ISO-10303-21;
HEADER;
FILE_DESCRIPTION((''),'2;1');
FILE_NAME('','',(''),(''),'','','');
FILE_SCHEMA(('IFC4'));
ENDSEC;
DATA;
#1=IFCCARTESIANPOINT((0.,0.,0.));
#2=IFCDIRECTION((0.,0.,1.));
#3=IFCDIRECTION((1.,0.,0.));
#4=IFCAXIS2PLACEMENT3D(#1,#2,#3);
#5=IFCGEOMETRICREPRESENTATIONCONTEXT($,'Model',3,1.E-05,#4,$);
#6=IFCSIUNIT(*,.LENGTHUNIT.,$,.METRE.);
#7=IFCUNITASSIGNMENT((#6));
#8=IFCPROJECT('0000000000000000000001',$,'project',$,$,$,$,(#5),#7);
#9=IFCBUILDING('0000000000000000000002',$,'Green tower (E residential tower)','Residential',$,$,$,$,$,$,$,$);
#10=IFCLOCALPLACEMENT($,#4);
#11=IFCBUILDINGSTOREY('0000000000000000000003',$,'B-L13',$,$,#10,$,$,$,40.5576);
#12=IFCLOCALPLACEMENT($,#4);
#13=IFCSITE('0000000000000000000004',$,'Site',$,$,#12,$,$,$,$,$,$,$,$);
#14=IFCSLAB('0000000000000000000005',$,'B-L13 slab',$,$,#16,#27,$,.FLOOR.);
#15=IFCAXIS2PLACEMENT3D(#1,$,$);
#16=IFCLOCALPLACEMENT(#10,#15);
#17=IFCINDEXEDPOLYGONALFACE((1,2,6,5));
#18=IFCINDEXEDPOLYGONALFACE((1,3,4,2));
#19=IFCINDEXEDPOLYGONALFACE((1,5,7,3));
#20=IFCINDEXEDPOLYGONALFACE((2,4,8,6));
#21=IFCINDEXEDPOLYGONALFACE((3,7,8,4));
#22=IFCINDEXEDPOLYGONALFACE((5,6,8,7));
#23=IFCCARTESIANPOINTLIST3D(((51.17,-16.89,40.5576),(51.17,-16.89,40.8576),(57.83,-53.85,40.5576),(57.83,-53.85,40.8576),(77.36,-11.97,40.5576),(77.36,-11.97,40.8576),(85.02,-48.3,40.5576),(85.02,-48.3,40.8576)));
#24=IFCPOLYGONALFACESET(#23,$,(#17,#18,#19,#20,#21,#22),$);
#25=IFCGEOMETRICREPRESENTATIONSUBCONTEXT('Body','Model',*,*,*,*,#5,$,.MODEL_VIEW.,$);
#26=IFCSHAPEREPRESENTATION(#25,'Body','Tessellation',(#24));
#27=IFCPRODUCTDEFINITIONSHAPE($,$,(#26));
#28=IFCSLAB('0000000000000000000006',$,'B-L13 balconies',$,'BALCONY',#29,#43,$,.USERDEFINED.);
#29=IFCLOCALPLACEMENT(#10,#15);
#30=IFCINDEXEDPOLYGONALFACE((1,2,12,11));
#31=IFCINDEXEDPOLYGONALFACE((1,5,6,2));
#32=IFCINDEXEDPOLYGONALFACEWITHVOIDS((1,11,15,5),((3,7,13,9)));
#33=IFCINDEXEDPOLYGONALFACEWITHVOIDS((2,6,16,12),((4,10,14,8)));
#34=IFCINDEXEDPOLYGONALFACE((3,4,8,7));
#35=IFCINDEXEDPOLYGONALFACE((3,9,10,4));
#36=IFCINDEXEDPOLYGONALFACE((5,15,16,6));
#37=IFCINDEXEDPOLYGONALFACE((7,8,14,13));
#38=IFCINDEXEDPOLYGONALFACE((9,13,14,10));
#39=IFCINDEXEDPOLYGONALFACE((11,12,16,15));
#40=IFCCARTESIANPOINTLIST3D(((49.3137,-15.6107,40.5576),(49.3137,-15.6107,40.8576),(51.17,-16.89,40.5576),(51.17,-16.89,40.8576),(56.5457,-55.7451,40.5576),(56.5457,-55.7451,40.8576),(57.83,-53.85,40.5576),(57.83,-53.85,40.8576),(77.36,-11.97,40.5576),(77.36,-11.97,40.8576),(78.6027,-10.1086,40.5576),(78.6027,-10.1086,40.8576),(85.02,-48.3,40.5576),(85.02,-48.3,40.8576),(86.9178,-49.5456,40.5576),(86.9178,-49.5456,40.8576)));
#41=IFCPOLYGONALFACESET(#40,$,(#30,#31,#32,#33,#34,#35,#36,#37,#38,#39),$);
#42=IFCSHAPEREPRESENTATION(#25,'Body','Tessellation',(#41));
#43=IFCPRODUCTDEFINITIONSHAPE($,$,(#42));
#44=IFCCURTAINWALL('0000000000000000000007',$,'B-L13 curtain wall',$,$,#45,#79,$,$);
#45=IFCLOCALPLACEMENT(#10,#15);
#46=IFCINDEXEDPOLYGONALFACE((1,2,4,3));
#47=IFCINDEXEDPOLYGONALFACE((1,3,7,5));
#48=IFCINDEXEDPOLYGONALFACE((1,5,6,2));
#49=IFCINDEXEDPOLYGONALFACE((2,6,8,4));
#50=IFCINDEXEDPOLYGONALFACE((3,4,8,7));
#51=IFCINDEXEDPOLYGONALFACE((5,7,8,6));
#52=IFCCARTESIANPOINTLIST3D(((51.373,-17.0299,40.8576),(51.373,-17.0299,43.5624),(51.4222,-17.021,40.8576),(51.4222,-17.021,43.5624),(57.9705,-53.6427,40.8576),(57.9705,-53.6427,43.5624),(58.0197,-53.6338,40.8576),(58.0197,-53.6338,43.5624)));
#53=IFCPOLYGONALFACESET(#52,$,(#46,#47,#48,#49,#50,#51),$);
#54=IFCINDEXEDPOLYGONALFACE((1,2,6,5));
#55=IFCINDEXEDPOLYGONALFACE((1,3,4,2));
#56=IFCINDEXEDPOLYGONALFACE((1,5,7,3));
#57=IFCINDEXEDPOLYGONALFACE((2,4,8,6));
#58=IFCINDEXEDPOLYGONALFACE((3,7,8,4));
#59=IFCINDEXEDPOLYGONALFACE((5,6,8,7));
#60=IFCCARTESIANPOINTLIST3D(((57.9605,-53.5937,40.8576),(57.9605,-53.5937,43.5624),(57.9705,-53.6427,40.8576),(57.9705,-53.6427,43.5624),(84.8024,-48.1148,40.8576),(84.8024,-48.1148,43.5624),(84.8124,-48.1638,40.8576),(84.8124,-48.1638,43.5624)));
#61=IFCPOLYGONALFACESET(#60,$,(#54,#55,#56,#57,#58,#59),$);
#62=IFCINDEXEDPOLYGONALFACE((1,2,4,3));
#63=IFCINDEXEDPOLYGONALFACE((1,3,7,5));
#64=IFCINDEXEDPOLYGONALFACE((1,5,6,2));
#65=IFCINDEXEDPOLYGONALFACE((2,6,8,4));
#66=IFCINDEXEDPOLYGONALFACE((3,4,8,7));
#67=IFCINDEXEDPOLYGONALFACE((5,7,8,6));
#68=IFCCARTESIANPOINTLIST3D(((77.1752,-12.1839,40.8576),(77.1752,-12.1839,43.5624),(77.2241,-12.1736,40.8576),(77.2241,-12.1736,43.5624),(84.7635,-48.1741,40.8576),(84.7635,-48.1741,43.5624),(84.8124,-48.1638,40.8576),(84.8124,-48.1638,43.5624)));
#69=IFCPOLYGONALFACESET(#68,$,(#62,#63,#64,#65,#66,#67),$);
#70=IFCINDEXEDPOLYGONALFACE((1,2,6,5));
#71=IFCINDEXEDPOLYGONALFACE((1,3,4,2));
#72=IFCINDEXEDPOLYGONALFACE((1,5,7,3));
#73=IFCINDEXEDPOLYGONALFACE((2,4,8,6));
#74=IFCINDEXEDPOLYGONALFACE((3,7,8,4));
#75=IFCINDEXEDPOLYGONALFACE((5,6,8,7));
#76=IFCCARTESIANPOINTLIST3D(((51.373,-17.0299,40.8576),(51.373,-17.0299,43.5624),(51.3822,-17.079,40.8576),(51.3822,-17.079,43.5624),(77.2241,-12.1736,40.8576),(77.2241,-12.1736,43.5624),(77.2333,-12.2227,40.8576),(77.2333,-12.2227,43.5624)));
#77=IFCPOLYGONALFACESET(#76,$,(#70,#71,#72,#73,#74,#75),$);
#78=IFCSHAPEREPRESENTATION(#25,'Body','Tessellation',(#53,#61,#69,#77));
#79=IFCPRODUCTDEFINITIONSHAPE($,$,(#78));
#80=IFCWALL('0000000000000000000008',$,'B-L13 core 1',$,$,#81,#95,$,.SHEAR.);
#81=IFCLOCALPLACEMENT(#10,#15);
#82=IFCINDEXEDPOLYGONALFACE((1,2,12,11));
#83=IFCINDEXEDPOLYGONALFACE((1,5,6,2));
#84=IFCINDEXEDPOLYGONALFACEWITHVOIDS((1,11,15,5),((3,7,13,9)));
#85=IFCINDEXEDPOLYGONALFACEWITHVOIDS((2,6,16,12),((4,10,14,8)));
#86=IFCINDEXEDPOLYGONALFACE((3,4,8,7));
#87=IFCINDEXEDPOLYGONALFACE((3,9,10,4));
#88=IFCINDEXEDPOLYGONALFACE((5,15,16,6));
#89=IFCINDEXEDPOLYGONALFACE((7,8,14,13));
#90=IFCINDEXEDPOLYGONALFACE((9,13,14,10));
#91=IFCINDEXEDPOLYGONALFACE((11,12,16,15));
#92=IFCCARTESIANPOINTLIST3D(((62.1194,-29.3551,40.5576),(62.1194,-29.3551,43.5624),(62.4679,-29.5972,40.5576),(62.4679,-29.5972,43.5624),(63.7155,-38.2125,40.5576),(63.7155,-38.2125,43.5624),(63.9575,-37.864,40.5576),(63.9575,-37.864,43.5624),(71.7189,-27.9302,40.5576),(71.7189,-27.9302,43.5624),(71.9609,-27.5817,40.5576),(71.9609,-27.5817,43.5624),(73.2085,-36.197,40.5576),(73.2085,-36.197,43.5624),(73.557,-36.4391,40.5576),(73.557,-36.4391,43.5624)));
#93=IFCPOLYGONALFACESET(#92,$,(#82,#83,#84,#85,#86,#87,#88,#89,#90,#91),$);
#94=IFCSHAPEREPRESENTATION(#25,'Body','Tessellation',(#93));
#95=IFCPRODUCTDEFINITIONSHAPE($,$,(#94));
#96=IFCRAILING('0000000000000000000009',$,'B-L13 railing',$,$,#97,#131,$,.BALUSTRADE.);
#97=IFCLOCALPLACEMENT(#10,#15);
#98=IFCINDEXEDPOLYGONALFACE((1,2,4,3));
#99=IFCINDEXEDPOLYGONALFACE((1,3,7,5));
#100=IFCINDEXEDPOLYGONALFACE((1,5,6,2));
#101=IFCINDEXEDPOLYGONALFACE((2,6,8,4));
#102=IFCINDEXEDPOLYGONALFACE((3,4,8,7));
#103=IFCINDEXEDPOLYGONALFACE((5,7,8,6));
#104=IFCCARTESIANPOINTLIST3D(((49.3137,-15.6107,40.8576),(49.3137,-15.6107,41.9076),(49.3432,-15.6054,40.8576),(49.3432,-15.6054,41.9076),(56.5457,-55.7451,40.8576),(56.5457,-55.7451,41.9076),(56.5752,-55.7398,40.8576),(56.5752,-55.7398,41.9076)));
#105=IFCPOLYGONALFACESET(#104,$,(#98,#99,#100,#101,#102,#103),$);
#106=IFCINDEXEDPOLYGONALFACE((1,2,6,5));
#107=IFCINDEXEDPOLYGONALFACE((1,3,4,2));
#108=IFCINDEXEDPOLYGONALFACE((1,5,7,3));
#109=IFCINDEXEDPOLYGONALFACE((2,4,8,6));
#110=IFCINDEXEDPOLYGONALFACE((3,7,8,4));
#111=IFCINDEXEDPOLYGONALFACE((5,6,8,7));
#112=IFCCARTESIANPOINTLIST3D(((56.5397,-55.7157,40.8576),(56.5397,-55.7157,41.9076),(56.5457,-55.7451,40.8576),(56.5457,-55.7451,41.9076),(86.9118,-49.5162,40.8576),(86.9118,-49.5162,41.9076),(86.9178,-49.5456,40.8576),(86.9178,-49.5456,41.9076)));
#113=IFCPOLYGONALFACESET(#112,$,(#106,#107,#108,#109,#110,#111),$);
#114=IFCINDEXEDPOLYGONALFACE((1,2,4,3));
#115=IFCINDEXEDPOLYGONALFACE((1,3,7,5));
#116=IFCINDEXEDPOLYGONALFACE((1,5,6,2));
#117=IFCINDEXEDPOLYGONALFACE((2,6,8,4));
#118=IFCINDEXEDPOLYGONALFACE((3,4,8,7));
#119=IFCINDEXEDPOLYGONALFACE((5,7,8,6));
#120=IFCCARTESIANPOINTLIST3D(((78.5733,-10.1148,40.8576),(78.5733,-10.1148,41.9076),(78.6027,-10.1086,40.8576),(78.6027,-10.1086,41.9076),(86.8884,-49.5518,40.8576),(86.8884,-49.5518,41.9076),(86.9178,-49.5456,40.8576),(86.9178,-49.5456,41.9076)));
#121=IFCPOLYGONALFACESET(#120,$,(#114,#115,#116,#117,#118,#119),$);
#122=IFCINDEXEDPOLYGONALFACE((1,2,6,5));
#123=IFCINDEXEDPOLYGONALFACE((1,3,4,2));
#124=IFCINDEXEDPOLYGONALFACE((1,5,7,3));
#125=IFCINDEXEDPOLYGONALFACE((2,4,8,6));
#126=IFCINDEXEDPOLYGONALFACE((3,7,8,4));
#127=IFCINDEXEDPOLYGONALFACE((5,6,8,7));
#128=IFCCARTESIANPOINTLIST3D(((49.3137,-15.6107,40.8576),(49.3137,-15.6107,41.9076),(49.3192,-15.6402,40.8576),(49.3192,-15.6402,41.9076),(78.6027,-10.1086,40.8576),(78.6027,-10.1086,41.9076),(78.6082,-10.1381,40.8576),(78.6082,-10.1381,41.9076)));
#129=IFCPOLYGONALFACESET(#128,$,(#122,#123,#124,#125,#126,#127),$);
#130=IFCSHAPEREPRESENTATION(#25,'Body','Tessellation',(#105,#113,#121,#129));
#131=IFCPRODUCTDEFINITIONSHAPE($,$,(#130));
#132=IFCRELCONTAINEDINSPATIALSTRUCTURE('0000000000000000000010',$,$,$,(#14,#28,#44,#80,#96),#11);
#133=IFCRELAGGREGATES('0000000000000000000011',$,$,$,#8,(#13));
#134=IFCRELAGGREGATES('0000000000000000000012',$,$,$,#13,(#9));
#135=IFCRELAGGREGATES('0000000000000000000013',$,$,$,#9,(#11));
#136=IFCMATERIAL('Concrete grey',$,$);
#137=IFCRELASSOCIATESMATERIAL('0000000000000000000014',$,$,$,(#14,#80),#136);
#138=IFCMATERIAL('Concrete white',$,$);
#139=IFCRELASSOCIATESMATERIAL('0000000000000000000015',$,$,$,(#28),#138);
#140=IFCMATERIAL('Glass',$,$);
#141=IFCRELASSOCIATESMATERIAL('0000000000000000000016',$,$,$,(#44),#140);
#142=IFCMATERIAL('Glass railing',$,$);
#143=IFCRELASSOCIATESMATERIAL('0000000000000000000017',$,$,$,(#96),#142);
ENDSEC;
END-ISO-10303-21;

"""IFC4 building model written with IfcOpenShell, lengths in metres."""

from ifc_helpers import new_model, si_unit, frame, origin_with_axes, place, context, subcontext, project, spatial, polyline, outline, extrude, material, element, save


model = new_model("IFC4")

# Units and contexts
model_context = context("Model", 3, precision=1e-05, world=origin_with_axes())
body_context = subcontext(model_context, "Body", "Model", "MODEL_VIEW")
ifc_project = project(units=[si_unit("LENGTHUNIT", "METRE")], contexts=[model_context])

# Site, building, storey
site_placement = place(None, origin_with_axes())
site = spatial("IfcSite", under=ifc_project, at=site_placement, Name="Site")
building = spatial("IfcBuilding", under=site, Name="Green tower (E residential tower)", Description="Residential")
storey_placement = place(None, origin_with_axes())
storey = spatial("IfcBuildingStorey", under=building, at=storey_placement, Name="B-L13", Elevation=40.5576)

# Slabs
ifc_material_1 = material(Name="Concrete grey")
slab_1_placement = place(storey_placement, origin_with_axes())
element("IfcSlab", 1, at=slab_1_placement, inside=storey, material=ifc_material_1, Name="B-L13 slab", PredefinedType="FLOOR", context=body_context, shape_type="SweptSolid", body=[
    extrude(outline(polyline([(51.17, -16.89), (57.83, -53.85), (85.02, -48.3), (77.36, -11.97), (51.17, -16.89)])), frame((0.0, 0.0, 40.5576), z_axis=(0.0, 0.0, 1.0), x_axis=(1.0, 0.0, 0.0)), (0.0, 0.0, 1.0), 0.3),
])
ifc_material_2 = material(Name="Concrete white")
slab_2_placement = place(storey_placement, origin_with_axes())
element("IfcSlab", 2, at=slab_2_placement, inside=storey, material=ifc_material_2, Name="B-L13 balconies", ObjectType="BALCONY", PredefinedType="USERDEFINED", context=body_context, shape_type="SweptSolid", body=[
    extrude(outline(polyline([(49.3137, -15.6107), (56.5457, -55.7451), (86.9178, -49.5456), (78.6027, -10.1086), (49.3137, -15.6107)]), holes=[polyline([(51.17, -16.89), (57.83, -53.85), (85.02, -48.3), (77.36, -11.97), (51.17, -16.89)])]), frame((0.0, 0.0, 40.5576), z_axis=(0.0, 0.0, 1.0), x_axis=(1.0, 0.0, 0.0)), (0.0, 0.0, 1.0), 0.3),
])

# Curtain wall
ifc_material_3 = material(Name="Glass")
curtain_wall_placement = place(storey_placement, origin_with_axes())
element("IfcCurtainWall", 3, at=curtain_wall_placement, inside=storey, material=ifc_material_3, Name="B-L13 curtain wall", context=body_context, shape_type="SweptSolid", body=[
    extrude(outline(polyline([(51.373, -17.0299), (57.9705, -53.6427), (58.0197, -53.6338), (51.4222, -17.021), (51.373, -17.0299)])), frame((0.0, 0.0, 40.8576), z_axis=(0.0, 0.0, 1.0), x_axis=(1.0, 0.0, 0.0)), (0.0, 0.0, 1.0), 2.7048),
    extrude(outline(polyline([(57.9705, -53.6427), (84.8124, -48.1638), (84.8024, -48.1148), (57.9605, -53.5937), (57.9705, -53.6427)])), frame((0.0, 0.0, 40.8576), z_axis=(0.0, 0.0, 1.0), x_axis=(1.0, 0.0, 0.0)), (0.0, 0.0, 1.0), 2.7048),
    extrude(outline(polyline([(84.8124, -48.1638), (77.2241, -12.1736), (77.1752, -12.1839), (84.7635, -48.1741), (84.8124, -48.1638)])), frame((0.0, 0.0, 40.8576), z_axis=(0.0, 0.0, 1.0), x_axis=(1.0, 0.0, 0.0)), (0.0, 0.0, 1.0), 2.7048),
    extrude(outline(polyline([(77.2241, -12.1736), (51.373, -17.0299), (51.3822, -17.079), (77.2333, -12.2227), (77.2241, -12.1736)])), frame((0.0, 0.0, 40.8576), z_axis=(0.0, 0.0, 1.0), x_axis=(1.0, 0.0, 0.0)), (0.0, 0.0, 1.0), 2.7048),
])

# Wall
wall_placement = place(storey_placement, origin_with_axes())
element("IfcWall", 4, at=wall_placement, inside=storey, material=ifc_material_1, Name="B-L13 core 1", PredefinedType="SHEAR", context=body_context, shape_type="SweptSolid", body=[
    extrude(outline(polyline([(62.1194, -29.3551), (63.7155, -38.2125), (73.557, -36.4391), (71.9609, -27.5817), (62.1194, -29.3551)]), holes=[polyline([(62.4679, -29.5972), (63.9575, -37.864), (73.2085, -36.197), (71.7189, -27.9302), (62.4679, -29.5972)])]), frame((0.0, 0.0, 40.5576), z_axis=(0.0, 0.0, 1.0), x_axis=(1.0, 0.0, 0.0)), (0.0, 0.0, 1.0), 3.0048),
])

# Railing
ifc_material_4 = material(Name="Glass railing")
railing_placement = place(storey_placement, origin_with_axes())
element("IfcRailing", 5, at=railing_placement, inside=storey, material=ifc_material_4, Name="B-L13 railing", PredefinedType="BALUSTRADE", context=body_context, shape_type="SweptSolid", body=[
    extrude(outline(polyline([(49.3137, -15.6107), (56.5457, -55.7451), (56.5752, -55.7398), (49.3432, -15.6054), (49.3137, -15.6107)])), frame((0.0, 0.0, 40.8576), z_axis=(0.0, 0.0, 1.0), x_axis=(1.0, 0.0, 0.0)), (0.0, 0.0, 1.0), 1.05),
    extrude(outline(polyline([(56.5457, -55.7451), (86.9178, -49.5456), (86.9118, -49.5162), (56.5397, -55.7157), (56.5457, -55.7451)])), frame((0.0, 0.0, 40.8576), z_axis=(0.0, 0.0, 1.0), x_axis=(1.0, 0.0, 0.0)), (0.0, 0.0, 1.0), 1.05),
    extrude(outline(polyline([(86.9178, -49.5456), (78.6027, -10.1086), (78.5733, -10.1148), (86.8884, -49.5518), (86.9178, -49.5456)])), frame((0.0, 0.0, 40.8576), z_axis=(0.0, 0.0, 1.0), x_axis=(1.0, 0.0, 0.0)), (0.0, 0.0, 1.0), 1.05),
    extrude(outline(polyline([(78.6027, -10.1086), (49.3137, -15.6107), (49.3192, -15.6402), (78.6082, -10.1381), (78.6027, -10.1086)])), frame((0.0, 0.0, 40.8576), z_axis=(0.0, 0.0, 1.0), x_axis=(1.0, 0.0, 0.0)), (0.0, 0.0, 1.0), 1.05),
])

save(model, "model.ifc")
